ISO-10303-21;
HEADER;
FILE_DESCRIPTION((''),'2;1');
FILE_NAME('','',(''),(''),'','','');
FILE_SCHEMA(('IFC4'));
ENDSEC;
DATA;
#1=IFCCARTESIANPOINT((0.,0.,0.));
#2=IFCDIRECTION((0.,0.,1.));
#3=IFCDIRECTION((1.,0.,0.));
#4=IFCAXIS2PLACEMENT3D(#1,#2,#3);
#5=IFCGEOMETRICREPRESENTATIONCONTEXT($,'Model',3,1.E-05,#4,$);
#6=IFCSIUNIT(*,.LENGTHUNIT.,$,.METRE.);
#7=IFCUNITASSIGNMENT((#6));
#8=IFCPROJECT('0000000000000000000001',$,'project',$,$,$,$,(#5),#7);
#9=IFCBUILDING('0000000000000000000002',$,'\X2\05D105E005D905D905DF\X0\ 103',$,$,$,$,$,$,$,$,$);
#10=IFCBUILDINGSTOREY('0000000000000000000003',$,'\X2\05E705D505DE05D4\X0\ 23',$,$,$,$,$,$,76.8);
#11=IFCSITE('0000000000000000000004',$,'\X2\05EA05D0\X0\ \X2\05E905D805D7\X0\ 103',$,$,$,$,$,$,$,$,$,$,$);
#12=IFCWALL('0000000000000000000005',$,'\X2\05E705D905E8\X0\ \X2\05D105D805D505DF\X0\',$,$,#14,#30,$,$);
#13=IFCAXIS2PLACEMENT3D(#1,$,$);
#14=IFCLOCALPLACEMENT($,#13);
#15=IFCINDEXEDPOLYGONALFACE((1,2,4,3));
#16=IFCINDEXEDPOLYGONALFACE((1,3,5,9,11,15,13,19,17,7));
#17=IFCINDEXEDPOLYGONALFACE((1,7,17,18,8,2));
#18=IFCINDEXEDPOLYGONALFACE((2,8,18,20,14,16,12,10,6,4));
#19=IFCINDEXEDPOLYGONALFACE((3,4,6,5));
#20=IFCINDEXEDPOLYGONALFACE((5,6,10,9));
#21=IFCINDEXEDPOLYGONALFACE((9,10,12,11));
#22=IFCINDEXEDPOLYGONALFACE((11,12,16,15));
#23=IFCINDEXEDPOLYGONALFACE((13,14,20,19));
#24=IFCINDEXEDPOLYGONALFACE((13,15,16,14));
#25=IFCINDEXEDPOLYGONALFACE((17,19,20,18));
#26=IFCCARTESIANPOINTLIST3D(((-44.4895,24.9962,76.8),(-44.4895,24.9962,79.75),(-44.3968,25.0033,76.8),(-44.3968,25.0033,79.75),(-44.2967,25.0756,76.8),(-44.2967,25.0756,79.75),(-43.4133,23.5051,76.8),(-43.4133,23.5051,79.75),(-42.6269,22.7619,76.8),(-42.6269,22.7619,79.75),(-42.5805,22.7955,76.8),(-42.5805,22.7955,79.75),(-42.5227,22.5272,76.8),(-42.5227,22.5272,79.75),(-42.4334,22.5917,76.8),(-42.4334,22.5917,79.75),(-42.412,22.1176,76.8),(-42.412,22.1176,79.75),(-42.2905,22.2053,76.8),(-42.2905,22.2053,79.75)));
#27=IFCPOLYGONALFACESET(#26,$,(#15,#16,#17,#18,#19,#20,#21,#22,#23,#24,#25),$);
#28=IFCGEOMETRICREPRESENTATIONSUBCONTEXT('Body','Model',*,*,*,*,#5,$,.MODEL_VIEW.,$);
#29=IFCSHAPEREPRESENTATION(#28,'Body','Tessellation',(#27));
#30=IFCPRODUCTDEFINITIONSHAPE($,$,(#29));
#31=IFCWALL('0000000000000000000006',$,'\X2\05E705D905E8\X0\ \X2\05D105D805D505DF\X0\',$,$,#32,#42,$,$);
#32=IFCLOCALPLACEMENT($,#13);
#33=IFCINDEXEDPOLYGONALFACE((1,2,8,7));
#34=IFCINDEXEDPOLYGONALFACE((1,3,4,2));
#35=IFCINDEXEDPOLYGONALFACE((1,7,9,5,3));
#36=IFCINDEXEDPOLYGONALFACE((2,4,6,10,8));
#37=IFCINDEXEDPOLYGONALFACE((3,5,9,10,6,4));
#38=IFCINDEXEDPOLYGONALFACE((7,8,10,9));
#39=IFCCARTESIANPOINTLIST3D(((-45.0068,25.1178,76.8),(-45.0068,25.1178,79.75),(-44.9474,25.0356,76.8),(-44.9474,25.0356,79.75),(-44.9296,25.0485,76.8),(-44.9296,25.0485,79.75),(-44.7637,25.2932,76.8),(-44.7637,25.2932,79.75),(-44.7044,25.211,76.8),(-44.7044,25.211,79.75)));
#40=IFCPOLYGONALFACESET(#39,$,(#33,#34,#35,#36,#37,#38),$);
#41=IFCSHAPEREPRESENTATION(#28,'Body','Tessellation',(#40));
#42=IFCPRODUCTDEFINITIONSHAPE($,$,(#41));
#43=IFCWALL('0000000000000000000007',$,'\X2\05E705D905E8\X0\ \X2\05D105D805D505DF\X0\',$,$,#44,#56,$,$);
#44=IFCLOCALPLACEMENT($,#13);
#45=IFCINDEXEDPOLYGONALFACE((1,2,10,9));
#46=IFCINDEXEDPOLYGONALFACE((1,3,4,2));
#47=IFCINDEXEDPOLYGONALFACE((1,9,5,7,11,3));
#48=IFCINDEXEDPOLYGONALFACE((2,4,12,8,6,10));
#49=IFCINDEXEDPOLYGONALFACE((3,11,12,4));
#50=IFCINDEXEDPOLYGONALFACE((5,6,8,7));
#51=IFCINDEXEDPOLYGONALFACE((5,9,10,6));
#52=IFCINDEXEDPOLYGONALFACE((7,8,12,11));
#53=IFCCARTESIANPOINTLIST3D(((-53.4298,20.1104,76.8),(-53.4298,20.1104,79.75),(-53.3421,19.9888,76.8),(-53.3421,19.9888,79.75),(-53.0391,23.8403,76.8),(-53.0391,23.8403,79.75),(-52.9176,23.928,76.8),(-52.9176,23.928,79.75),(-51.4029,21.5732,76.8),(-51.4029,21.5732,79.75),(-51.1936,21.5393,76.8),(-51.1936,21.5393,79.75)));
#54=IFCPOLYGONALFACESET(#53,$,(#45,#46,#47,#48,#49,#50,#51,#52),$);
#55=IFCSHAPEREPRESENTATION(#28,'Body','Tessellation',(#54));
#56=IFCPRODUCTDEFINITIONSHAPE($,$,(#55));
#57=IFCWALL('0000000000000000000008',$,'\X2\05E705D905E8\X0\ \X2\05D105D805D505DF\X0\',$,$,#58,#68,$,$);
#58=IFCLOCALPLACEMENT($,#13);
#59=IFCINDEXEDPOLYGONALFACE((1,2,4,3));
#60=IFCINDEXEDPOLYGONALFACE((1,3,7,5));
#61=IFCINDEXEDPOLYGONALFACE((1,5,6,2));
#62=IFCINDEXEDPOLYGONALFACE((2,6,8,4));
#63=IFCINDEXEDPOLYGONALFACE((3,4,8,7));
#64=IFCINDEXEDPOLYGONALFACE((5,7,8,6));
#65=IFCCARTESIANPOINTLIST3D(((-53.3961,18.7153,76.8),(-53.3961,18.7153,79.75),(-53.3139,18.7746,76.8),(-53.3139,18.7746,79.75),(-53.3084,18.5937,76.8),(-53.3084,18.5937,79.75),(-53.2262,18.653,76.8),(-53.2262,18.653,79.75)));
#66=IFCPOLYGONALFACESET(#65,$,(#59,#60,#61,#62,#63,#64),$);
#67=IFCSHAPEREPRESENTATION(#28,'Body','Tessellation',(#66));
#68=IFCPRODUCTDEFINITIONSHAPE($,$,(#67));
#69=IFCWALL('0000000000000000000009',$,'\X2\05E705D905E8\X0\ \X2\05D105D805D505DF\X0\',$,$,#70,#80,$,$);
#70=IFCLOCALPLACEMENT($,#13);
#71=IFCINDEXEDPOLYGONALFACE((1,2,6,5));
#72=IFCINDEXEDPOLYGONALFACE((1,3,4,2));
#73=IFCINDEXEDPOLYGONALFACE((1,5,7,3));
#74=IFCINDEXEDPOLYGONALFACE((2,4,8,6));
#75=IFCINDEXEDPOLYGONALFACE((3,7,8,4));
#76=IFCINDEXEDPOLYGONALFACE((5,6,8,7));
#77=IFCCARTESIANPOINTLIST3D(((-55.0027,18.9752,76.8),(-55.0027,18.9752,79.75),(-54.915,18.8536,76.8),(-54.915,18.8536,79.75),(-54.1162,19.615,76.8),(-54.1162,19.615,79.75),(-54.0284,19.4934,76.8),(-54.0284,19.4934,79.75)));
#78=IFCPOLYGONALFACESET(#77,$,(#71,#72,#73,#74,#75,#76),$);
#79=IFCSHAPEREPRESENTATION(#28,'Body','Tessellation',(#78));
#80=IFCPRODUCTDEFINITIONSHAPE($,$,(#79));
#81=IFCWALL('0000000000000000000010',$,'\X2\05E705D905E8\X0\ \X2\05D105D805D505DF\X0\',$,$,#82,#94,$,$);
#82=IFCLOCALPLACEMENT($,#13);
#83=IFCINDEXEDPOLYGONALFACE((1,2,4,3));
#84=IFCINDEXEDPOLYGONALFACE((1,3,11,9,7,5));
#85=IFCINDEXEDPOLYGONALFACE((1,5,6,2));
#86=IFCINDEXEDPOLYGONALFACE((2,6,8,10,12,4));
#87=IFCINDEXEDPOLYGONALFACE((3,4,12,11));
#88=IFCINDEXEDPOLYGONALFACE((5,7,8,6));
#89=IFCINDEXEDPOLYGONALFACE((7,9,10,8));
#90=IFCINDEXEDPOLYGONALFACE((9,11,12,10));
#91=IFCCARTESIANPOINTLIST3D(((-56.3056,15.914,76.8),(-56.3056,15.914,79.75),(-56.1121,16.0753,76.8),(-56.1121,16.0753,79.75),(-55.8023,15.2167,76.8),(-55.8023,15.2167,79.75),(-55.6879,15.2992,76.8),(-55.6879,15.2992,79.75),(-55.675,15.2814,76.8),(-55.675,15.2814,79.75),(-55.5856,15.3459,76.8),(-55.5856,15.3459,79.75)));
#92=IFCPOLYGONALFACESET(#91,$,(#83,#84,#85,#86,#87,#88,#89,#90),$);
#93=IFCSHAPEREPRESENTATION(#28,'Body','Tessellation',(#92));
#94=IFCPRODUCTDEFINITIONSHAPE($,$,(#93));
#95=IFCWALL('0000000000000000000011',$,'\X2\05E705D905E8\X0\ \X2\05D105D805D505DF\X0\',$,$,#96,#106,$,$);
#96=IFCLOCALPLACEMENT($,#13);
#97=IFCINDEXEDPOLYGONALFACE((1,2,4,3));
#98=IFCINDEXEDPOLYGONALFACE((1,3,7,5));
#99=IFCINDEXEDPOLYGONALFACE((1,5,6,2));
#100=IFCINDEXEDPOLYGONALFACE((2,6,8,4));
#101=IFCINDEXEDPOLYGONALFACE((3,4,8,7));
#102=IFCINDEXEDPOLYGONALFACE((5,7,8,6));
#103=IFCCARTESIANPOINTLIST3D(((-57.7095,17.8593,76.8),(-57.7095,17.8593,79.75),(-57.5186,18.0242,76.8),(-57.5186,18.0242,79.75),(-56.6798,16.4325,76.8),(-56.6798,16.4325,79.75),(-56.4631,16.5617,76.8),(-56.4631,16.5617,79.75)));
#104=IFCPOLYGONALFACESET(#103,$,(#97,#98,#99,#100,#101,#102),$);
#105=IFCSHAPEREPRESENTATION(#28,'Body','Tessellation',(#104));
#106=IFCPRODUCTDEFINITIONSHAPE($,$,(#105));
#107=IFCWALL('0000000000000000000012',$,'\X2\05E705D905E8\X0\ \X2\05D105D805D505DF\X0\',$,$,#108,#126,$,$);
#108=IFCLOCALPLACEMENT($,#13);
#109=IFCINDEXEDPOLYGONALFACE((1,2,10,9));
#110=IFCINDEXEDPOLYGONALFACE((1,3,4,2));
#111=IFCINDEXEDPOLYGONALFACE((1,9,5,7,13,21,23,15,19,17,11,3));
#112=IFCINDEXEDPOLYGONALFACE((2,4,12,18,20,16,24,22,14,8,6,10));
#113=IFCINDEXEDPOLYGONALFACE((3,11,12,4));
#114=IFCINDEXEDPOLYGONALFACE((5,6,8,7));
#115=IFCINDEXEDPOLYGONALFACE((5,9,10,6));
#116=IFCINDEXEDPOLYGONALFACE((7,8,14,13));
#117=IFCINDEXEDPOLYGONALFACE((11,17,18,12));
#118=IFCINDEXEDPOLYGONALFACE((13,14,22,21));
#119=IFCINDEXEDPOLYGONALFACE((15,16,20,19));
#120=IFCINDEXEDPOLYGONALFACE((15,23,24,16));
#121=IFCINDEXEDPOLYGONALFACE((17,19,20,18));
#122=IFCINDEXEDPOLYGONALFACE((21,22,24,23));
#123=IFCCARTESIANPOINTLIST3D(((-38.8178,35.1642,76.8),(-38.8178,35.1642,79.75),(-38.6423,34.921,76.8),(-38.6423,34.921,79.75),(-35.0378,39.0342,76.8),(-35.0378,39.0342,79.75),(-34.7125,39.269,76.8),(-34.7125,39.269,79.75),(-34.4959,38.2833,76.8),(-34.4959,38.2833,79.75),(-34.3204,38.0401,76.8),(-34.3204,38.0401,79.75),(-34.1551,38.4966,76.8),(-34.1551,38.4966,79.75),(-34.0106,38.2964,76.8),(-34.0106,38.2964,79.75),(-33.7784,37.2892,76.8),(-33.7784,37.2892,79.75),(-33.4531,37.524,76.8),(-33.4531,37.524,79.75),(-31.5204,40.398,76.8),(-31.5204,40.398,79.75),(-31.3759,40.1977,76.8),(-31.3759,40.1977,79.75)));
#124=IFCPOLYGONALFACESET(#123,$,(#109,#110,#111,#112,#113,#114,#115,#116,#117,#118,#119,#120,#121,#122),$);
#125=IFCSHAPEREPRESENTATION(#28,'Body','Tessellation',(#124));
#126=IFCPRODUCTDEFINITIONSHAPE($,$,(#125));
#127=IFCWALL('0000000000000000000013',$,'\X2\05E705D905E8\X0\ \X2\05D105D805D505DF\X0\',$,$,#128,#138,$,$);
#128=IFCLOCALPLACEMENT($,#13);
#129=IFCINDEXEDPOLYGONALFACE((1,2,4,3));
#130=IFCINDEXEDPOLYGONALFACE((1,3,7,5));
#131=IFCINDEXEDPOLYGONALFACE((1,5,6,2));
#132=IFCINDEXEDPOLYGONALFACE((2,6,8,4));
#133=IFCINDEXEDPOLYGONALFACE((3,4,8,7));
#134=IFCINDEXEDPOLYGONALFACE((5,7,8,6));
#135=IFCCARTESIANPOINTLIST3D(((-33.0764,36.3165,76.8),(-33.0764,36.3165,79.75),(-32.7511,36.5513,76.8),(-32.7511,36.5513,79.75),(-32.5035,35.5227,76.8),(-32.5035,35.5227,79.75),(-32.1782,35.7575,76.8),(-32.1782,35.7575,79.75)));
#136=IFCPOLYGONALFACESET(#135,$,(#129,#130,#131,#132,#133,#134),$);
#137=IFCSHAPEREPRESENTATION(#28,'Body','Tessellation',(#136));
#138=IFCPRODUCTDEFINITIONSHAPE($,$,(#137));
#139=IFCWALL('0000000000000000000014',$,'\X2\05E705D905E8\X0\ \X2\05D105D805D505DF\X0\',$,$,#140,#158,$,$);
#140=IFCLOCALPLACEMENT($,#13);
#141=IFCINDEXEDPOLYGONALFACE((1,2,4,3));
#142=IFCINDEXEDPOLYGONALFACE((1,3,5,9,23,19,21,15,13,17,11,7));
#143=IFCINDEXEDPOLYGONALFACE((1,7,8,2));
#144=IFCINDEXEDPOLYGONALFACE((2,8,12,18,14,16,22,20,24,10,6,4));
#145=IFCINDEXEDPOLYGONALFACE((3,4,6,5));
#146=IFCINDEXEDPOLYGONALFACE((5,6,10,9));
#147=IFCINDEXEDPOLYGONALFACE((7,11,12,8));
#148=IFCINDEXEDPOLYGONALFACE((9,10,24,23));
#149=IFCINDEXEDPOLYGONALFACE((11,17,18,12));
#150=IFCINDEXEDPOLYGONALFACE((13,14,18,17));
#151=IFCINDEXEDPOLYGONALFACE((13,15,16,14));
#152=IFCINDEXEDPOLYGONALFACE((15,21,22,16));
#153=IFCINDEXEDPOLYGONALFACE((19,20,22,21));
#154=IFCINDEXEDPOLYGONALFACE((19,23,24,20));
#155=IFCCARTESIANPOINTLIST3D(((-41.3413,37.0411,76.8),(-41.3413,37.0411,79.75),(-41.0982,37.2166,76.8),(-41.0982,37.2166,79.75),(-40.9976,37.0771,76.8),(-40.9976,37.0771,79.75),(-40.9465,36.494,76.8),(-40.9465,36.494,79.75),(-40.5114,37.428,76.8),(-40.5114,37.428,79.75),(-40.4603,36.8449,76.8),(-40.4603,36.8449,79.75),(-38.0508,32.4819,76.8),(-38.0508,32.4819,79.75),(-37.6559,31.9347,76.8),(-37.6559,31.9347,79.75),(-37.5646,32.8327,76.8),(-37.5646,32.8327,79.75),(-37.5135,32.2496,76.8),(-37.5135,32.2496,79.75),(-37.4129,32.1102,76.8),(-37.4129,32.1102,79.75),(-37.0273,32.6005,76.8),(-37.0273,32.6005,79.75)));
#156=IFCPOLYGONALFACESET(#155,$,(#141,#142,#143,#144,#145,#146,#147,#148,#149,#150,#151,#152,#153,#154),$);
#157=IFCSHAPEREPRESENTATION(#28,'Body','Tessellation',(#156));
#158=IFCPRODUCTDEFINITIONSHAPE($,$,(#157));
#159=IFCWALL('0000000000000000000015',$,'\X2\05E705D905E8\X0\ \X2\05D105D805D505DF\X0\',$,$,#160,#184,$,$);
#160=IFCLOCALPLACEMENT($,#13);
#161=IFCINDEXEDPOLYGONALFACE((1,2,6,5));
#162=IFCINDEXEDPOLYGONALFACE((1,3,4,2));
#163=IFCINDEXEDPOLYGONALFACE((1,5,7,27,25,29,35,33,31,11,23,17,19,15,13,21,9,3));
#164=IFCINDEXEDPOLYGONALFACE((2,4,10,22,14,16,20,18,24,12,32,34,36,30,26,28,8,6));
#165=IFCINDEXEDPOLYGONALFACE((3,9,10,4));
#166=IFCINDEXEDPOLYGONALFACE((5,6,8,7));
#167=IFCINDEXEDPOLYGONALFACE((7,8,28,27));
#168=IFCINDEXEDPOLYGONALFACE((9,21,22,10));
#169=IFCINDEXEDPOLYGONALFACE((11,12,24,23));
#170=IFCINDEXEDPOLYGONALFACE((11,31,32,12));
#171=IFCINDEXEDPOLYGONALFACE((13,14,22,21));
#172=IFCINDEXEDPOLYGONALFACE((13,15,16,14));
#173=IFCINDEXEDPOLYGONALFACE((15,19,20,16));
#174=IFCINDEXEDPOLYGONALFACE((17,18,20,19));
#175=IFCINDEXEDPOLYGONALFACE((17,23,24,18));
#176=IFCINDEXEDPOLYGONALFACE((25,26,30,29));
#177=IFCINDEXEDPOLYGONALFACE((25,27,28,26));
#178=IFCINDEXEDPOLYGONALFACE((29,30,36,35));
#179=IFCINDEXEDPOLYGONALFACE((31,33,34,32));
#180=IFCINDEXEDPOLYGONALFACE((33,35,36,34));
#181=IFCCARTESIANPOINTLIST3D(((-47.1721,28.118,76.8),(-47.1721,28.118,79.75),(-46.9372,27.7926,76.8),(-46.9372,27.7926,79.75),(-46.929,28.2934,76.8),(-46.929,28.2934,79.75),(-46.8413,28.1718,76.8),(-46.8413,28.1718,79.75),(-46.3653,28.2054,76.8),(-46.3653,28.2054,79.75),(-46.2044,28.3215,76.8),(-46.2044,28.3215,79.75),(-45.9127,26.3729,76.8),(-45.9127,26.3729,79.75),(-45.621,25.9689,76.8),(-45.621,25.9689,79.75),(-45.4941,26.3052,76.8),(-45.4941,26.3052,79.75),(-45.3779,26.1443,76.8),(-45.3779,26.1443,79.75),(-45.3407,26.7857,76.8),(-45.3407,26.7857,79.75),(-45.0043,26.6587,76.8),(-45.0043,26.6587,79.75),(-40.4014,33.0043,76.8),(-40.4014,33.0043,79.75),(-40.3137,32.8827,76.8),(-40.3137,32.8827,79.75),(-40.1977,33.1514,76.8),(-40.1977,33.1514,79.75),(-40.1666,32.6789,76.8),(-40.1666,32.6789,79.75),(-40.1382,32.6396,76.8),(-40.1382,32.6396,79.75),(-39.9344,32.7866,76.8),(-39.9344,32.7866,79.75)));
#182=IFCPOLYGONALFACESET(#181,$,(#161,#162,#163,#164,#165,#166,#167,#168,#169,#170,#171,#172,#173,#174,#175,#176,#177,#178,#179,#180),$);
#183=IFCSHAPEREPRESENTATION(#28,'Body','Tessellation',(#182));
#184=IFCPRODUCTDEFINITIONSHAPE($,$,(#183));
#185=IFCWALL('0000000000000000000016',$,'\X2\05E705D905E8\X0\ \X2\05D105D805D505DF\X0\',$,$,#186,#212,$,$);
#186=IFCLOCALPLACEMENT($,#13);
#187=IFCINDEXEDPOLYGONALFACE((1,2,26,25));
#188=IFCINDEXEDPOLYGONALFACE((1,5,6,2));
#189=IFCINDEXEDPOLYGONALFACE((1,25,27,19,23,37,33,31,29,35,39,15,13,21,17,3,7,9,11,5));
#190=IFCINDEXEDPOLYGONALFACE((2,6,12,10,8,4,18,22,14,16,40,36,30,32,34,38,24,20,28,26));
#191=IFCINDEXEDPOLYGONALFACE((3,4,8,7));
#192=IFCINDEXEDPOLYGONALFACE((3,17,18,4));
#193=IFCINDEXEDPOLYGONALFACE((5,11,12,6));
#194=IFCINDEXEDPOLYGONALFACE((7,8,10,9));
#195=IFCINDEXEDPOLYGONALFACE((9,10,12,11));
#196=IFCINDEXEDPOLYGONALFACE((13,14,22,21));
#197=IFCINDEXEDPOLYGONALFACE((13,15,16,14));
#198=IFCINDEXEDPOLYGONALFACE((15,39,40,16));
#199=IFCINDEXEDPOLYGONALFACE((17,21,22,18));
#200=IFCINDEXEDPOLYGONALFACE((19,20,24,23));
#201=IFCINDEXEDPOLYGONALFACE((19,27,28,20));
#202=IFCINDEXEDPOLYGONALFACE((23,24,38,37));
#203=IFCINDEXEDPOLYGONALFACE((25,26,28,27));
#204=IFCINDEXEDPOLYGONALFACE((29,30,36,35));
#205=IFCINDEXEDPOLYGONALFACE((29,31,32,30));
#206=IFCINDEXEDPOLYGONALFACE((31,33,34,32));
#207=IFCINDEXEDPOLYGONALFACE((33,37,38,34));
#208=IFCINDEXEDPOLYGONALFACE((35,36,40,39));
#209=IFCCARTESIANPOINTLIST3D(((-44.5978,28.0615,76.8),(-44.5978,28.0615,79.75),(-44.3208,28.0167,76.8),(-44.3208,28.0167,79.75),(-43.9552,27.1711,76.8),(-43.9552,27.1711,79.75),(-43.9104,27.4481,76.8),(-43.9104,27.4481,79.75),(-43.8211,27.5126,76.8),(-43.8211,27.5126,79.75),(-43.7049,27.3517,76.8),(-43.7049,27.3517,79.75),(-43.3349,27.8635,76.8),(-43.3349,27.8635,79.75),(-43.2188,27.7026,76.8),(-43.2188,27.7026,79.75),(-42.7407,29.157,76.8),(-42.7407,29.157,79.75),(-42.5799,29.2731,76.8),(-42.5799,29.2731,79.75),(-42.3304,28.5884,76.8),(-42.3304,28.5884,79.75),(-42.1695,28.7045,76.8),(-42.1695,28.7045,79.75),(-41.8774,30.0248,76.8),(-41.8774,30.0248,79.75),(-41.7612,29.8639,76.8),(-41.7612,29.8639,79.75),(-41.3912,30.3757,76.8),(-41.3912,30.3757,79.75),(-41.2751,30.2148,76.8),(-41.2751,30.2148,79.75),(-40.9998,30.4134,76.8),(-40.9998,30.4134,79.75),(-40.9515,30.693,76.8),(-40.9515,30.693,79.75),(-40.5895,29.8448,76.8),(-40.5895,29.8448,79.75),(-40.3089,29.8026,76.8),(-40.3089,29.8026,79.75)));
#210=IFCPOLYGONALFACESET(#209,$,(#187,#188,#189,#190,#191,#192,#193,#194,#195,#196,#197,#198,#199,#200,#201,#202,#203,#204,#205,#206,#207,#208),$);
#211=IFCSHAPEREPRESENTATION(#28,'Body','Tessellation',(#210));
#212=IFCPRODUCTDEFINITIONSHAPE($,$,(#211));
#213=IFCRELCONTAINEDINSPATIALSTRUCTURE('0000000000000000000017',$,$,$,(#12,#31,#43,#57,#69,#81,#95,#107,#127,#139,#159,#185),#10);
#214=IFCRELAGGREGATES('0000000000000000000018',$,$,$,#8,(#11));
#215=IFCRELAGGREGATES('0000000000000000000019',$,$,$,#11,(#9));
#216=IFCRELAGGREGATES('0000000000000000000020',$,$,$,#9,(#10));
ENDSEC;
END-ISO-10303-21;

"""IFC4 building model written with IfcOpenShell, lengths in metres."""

from ifc_helpers import new_model, si_unit, frame, origin_with_axes, context, subcontext, project, spatial, polyline, outline, extrude, element, save


model = new_model("IFC4")

# Units and contexts
model_context = context("Model", 3, precision=1e-05, world=origin_with_axes())
body_context = subcontext(model_context, "Body", "Model", "MODEL_VIEW")
ifc_project = project(units=[si_unit("LENGTHUNIT", "METRE")], contexts=[model_context])

# Site, building, storey
site = spatial("IfcSite", under=ifc_project, Name="תא שטח 103")
building = spatial("IfcBuilding", under=site, Name="בניין 103")
storey = spatial("IfcBuildingStorey", under=building, Name="קומה 23", Elevation=76.8)

# Walls
element("IfcWall", 1, inside=storey, Name="קיר בטון", context=body_context, shape_type="SweptSolid", body=[
    extrude(outline(polyline([(-42.412, 22.1176), (-43.4133, 23.5051), (-44.4895, 24.9962), (-44.3968, 25.0033), (-44.2967, 25.0756), (-42.6269, 22.7619), (-42.5805, 22.7955), (-42.4334, 22.5917), (-42.5227, 22.5272), (-42.2905, 22.2053), (-42.412, 22.1176)])), frame((0.0, 0.0, 76.8)), (0.0, 0.0, 1.0), 2.95),
])
element("IfcWall", 2, inside=storey, Name="קיר בטון", context=body_context, shape_type="SweptSolid", body=[
    extrude(outline(polyline([(-44.7637, 25.2932), (-44.7044, 25.211), (-44.9296, 25.0485), (-44.9474, 25.0356), (-45.0068, 25.1178), (-44.7637, 25.2932)])), frame((0.0, 0.0, 76.8)), (0.0, 0.0, 1.0), 2.95),
])
element("IfcWall", 3, inside=storey, Name="קיר בטון", context=body_context, shape_type="SweptSolid", body=[
    extrude(outline(polyline([(-53.4298, 20.1104), (-51.4029, 21.5732), (-53.0391, 23.8403), (-52.9176, 23.928), (-51.1936, 21.5393), (-53.3421, 19.9888), (-53.4298, 20.1104)])), frame((0.0, 0.0, 76.8)), (0.0, 0.0, 1.0), 2.95),
])
element("IfcWall", 4, inside=storey, Name="קיר בטון", context=body_context, shape_type="SweptSolid", body=[
    extrude(outline(polyline([(-53.2262, 18.653), (-53.3084, 18.5937), (-53.3961, 18.7153), (-53.3139, 18.7746), (-53.2262, 18.653)])), frame((0.0, 0.0, 76.8)), (0.0, 0.0, 1.0), 2.95),
])
element("IfcWall", 5, inside=storey, Name="קיר בטון", context=body_context, shape_type="SweptSolid", body=[
    extrude(outline(polyline([(-54.915, 18.8536), (-55.0027, 18.9752), (-54.1162, 19.615), (-54.0284, 19.4934), (-54.915, 18.8536)])), frame((0.0, 0.0, 76.8)), (0.0, 0.0, 1.0), 2.95),
])
element("IfcWall", 6, inside=storey, Name="קיר בטון", context=body_context, shape_type="SweptSolid", body=[
    extrude(outline(polyline([(-55.6879, 15.2992), (-55.8023, 15.2167), (-56.3056, 15.914), (-56.1121, 16.0753), (-55.5856, 15.3459), (-55.675, 15.2814), (-55.6879, 15.2992)])), frame((0.0, 0.0, 76.8)), (0.0, 0.0, 1.0), 2.95),
])
element("IfcWall", 7, inside=storey, Name="קיר בטון", context=body_context, shape_type="SweptSolid", body=[
    extrude(outline(polyline([(-56.6798, 16.4325), (-57.7095, 17.8593), (-57.5186, 18.0242), (-56.4631, 16.5617), (-56.6798, 16.4325)])), frame((0.0, 0.0, 76.8)), (0.0, 0.0, 1.0), 2.95),
])
element("IfcWall", 8, inside=storey, Name="קיר בטון", context=body_context, shape_type="SweptSolid", body=[
    extrude(outline(polyline([(-31.5204, 40.398), (-31.3759, 40.1977), (-34.0106, 38.2964), (-33.4531, 37.524), (-33.7784, 37.2892), (-34.3204, 38.0401), (-38.6423, 34.921), (-38.8178, 35.1642), (-34.4959, 38.2833), (-35.0378, 39.0342), (-34.7125, 39.269), (-34.1551, 38.4966), (-31.5204, 40.398)])), frame((0.0, 0.0, 76.8)), (0.0, 0.0, 1.0), 2.95),
])
element("IfcWall", 9, inside=storey, Name="קיר בטון", context=body_context, shape_type="SweptSolid", body=[
    extrude(outline(polyline([(-32.7511, 36.5513), (-32.1782, 35.7575), (-32.5035, 35.5227), (-33.0764, 36.3165), (-32.7511, 36.5513)])), frame((0.0, 0.0, 76.8)), (0.0, 0.0, 1.0), 2.95),
])
element("IfcWall", 10, inside=storey, Name="קיר בטון", context=body_context, shape_type="SweptSolid", body=[
    extrude(outline(polyline([(-37.6559, 31.9347), (-38.0508, 32.4819), (-37.5646, 32.8327), (-40.4603, 36.8449), (-40.9465, 36.494), (-41.3413, 37.0411), (-41.0982, 37.2166), (-40.9976, 37.0771), (-40.5114, 37.428), (-37.0273, 32.6005), (-37.5135, 32.2496), (-37.4129, 32.1102), (-37.6559, 31.9347)])), frame((0.0, 0.0, 76.8)), (0.0, 0.0, 1.0), 2.95),
])
element("IfcWall", 11, inside=storey, Name="קיר בטון", context=body_context, shape_type="SweptSolid", body=[
    extrude(outline(polyline([(-40.1382, 32.6396), (-40.1666, 32.6789), (-46.2044, 28.3215), (-45.0043, 26.6587), (-45.4941, 26.3052), (-45.3779, 26.1443), (-45.621, 25.9689), (-45.9127, 26.3729), (-45.3407, 26.7857), (-46.3653, 28.2054), (-46.9372, 27.7926), (-47.1721, 28.118), (-46.929, 28.2934), (-46.8413, 28.1718), (-40.3137, 32.8827), (-40.4014, 33.0043), (-40.1977, 33.1514), (-39.9344, 32.7866), (-40.1382, 32.6396)])), frame((0.0, 0.0, 76.8)), (0.0, 0.0, 1.0), 2.95),
])
element("IfcWall", 12, inside=storey, Name="קיר בטון", context=body_context, shape_type="SweptSolid", body=[
    extrude(outline(polyline([(-42.3304, 28.5884), (-42.7407, 29.157), (-44.3208, 28.0167), (-43.9104, 27.4481), (-43.8211, 27.5126), (-43.7049, 27.3517), (-43.9552, 27.1711), (-44.5978, 28.0615), (-41.8774, 30.0248), (-41.7612, 29.8639), (-42.5799, 29.2731), (-42.1695, 28.7045), (-40.5895, 29.8448), (-40.9998, 30.4134), (-41.2751, 30.2148), (-41.3912, 30.3757), (-40.9515, 30.693), (-40.3089, 29.8026), (-43.2188, 27.7026), (-43.3349, 27.8635), (-42.3304, 28.5884)])), frame((0.0, 0.0, 76.8)), (0.0, 0.0, 1.0), 2.95),
])

save(model, "model.ifc")
